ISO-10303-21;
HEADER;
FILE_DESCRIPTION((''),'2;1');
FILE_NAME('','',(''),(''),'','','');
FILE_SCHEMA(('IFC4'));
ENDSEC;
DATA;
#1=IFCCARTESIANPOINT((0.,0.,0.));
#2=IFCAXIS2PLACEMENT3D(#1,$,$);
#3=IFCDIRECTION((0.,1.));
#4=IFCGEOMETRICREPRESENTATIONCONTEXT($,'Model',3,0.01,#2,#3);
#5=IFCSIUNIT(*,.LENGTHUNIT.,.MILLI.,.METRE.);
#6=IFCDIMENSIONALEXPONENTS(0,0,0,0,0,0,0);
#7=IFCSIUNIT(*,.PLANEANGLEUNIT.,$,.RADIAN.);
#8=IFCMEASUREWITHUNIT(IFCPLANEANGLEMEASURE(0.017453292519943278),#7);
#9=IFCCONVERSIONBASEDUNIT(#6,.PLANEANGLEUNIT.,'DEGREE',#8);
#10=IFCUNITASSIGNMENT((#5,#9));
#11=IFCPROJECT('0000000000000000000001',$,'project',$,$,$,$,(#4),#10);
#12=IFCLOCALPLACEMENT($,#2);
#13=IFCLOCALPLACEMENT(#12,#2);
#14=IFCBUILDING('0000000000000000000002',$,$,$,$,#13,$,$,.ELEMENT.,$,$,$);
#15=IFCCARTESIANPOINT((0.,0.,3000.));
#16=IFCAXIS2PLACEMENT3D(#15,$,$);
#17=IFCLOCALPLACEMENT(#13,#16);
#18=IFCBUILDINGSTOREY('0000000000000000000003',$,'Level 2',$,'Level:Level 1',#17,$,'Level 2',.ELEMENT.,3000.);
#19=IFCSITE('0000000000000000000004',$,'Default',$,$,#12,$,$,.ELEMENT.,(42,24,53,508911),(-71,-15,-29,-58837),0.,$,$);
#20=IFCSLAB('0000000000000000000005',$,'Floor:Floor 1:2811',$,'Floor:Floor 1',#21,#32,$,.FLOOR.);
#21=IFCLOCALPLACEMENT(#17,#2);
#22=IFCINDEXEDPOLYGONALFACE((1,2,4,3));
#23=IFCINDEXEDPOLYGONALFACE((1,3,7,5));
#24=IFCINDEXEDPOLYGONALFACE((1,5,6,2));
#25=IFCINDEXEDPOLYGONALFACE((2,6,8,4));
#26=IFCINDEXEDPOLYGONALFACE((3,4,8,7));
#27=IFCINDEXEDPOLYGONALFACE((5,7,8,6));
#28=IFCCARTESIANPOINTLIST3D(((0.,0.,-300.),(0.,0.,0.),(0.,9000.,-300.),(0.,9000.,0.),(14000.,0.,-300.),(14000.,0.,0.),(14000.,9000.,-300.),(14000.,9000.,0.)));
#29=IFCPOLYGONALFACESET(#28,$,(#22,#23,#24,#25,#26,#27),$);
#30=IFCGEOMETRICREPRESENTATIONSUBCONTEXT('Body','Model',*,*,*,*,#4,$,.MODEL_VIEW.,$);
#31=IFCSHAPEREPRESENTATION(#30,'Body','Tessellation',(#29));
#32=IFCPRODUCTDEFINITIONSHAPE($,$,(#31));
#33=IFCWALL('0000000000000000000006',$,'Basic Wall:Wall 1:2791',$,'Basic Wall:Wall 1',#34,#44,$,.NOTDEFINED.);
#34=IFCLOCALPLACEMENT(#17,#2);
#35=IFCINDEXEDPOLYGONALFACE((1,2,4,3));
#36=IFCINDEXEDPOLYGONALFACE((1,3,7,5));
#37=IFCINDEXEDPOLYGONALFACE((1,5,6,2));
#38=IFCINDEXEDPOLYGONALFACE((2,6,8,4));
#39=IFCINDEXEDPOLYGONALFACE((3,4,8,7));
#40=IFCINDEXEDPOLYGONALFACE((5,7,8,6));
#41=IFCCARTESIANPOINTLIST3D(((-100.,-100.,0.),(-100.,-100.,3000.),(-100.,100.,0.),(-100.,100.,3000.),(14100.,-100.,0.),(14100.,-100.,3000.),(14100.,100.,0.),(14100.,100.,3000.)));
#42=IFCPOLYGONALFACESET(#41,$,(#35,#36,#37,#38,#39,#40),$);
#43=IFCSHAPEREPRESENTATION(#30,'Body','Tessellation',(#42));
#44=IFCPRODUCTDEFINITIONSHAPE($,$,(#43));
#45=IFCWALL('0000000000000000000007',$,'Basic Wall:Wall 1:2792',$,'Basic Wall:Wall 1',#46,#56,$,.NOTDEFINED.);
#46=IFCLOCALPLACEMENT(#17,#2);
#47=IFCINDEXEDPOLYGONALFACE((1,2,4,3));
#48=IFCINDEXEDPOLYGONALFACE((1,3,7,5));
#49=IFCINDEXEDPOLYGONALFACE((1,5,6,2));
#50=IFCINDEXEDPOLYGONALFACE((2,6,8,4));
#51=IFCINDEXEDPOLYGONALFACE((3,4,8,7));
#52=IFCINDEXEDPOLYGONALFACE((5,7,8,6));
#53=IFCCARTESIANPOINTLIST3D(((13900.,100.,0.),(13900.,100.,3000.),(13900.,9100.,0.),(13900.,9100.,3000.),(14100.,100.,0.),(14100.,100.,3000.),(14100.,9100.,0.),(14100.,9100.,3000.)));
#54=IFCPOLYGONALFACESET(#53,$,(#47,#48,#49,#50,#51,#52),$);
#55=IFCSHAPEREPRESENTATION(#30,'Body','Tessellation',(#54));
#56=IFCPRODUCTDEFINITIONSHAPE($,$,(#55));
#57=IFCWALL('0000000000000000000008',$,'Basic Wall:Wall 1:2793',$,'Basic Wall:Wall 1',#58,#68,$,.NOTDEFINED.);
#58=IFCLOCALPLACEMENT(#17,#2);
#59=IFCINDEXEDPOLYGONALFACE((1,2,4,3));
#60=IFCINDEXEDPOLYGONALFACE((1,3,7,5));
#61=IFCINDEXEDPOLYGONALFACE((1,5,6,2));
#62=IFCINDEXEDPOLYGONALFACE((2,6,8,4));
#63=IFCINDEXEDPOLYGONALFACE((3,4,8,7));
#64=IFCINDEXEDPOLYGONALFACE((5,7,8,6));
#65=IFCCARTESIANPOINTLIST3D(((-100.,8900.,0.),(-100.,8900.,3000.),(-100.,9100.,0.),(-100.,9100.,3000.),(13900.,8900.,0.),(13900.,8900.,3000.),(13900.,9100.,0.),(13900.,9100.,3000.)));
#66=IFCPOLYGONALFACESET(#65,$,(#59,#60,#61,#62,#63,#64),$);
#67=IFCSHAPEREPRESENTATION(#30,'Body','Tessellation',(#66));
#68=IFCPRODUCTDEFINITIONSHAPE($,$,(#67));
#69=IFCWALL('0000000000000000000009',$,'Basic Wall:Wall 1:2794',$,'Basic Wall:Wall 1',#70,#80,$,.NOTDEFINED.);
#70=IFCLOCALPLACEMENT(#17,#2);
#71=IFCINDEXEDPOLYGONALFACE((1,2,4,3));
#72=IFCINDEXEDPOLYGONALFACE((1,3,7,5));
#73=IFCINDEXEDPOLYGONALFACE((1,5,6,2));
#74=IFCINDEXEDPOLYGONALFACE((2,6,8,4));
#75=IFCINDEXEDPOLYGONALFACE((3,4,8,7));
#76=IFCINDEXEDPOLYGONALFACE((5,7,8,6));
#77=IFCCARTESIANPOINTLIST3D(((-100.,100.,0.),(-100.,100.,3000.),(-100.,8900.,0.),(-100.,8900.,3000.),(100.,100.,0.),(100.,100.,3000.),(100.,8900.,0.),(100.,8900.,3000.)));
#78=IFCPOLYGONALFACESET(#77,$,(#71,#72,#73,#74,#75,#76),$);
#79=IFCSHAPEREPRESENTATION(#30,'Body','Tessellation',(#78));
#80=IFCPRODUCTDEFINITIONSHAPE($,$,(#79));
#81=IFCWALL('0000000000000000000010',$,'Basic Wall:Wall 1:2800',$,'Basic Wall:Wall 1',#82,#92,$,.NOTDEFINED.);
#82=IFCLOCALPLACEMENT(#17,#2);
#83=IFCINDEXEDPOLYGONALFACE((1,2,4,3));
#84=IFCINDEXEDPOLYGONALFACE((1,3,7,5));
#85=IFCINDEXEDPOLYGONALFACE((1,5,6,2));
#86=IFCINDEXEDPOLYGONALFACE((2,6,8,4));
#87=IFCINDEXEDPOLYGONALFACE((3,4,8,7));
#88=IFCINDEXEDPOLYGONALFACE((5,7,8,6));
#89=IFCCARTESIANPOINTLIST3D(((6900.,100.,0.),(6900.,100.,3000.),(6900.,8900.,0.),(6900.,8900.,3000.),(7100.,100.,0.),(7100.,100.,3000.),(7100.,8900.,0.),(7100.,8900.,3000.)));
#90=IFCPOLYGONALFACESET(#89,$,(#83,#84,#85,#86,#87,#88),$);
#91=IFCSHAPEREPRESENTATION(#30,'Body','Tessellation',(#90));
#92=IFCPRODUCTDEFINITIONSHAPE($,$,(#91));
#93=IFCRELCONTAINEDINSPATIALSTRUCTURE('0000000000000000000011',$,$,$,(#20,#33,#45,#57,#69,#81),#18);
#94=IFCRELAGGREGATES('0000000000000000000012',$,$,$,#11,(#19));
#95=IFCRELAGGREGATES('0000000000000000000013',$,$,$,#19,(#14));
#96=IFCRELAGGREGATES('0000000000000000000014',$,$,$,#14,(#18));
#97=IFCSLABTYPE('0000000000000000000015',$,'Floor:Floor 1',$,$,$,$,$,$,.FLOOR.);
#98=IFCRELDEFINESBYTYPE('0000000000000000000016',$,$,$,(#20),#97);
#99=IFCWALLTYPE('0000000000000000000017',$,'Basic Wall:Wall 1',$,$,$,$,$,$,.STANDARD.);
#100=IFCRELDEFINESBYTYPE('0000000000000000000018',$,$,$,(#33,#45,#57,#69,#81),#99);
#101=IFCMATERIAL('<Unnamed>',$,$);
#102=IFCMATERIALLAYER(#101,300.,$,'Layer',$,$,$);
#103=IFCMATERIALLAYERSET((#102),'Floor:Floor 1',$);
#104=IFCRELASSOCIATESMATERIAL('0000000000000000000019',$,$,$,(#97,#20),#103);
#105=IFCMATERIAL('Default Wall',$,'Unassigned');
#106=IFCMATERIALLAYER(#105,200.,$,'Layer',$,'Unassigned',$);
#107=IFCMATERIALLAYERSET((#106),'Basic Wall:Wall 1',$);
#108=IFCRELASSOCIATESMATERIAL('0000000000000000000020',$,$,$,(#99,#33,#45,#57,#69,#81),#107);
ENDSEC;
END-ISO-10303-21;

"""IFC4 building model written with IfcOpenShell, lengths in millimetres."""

from ifc_helpers import new_model, entity, si_unit, converted_unit, direction, frame, frame_2d, origin, origin_2d_with_axis, place, context, subcontext, project, spatial, rectangle, extrude, material, layer, layer_set, layer_usage, type_object, element, save


model = new_model("IFC4")

# Units and contexts
model_context = context("Model", 3, precision=0.01, world=origin(), true_north=direction((0.0, 1.0)))
body_context = subcontext(model_context, "Body", "Model", "MODEL_VIEW")
ifc_project = project(units=[si_unit("LENGTHUNIT", "METRE", prefix="MILLI"), converted_unit("PLANEANGLEUNIT", "DEGREE", entity("IfcPlaneAngleMeasure", 0.017453292519943278), si_unit("PLANEANGLEUNIT", "RADIAN"), dimensions=[0, 0, 0, 0, 0, 0, 0])], contexts=[model_context])

# Site, building, storey
site_placement = place(None, origin())
site = spatial("IfcSite", under=ifc_project, at=site_placement, Name="Default", CompositionType="ELEMENT", RefLatitude=(42, 24, 53, 508911), RefLongitude=(-71, -15, -29, -58837), RefElevation=0.0)
building_placement = place(site_placement, origin())
building = spatial("IfcBuilding", under=site, at=building_placement, CompositionType="ELEMENT")
storey_placement = place(building_placement, frame((0.0, 0.0, 3000.0)))
storey = spatial("IfcBuildingStorey", under=building, at=storey_placement, Name="Level 2", ObjectType="Level:Level 1", LongName="Level 2", CompositionType="ELEMENT", Elevation=3000.0)

# Slab
ifc_material_1 = material(Name="<Unnamed>")
ifc_layer_1 = layer(ifc_material_1, 300.0, Name="Layer")
ifc_layer_set_1 = layer_set([ifc_layer_1], Name="Floor:Floor 1")
ifc_layer_usage_1 = layer_usage(ifc_layer_set_1, "AXIS3", "POSITIVE", 0.0)
slab_type = type_object("IfcSlabType", Name="Floor:Floor 1", PredefinedType="FLOOR", material=ifc_layer_set_1)
slab_placement = place(storey_placement, origin())
element("IfcSlab", 1, at=slab_placement, inside=storey, type_object=slab_type, material=ifc_layer_usage_1, Name="Floor:Floor 1:2811", ObjectType="Floor:Floor 1", PredefinedType="FLOOR", context=body_context, shape_type="SweptSolid", body=[
    extrude(rectangle(XDim=9000.0, YDim=14000.0, at=origin_2d_with_axis()), frame((7000.0, 4500.0, 0.0), z_axis=(0.0, 0.0, -1.0), x_axis=(0.0, 1.0, 0.0)), (0.0, 0.0, 1.0), 300.0),
])

# Walls
ifc_material_2 = material(Name="Default Wall", Category="Unassigned")
ifc_layer_2 = layer(ifc_material_2, 200.0, Name="Layer", Category="Unassigned")
ifc_layer_set_2 = layer_set([ifc_layer_2], Name="Basic Wall:Wall 1")
ifc_layer_usage_2 = layer_usage(ifc_layer_set_2, "AXIS2", "NEGATIVE", 100.0)
wall_type = type_object("IfcWallType", Name="Basic Wall:Wall 1", PredefinedType="STANDARD", material=ifc_layer_set_2)
wall_1_placement = place(storey_placement, frame((-100.0, 0.0, 0.0)))
element("IfcWall", 2, at=wall_1_placement, inside=storey, type_object=wall_type, material=ifc_layer_usage_2, Name="Basic Wall:Wall 1:2791", ObjectType="Basic Wall:Wall 1", PredefinedType="NOTDEFINED", context=body_context, shape_type="SweptSolid", body=[
    extrude(rectangle(XDim=14200.0, YDim=200.0, at=frame_2d((7100.0, 0.0), x_axis=(-1.0, 0.0))), origin(), (0.0, 0.0, 1.0), 3000.0),
])
ifc_layer_usage_3 = layer_usage(ifc_layer_set_2, "AXIS2", "NEGATIVE", 100.0)
wall_2_placement = place(storey_placement, frame((14000.0, 100.0, 0.0), z_axis=(0.0, 0.0, 1.0), x_axis=(0.0, 1.0, 0.0)))
element("IfcWall", 3, at=wall_2_placement, inside=storey, type_object=wall_type, material=ifc_layer_usage_3, Name="Basic Wall:Wall 1:2792", ObjectType="Basic Wall:Wall 1", PredefinedType="NOTDEFINED", context=body_context, shape_type="SweptSolid", body=[
    extrude(rectangle(XDim=9000.0, YDim=200.0, at=frame_2d((4500.0, 0.0), x_axis=(-1.0, 0.0))), origin(), (0.0, 0.0, 1.0), 3000.0),
])
ifc_layer_usage_4 = layer_usage(ifc_layer_set_2, "AXIS2", "NEGATIVE", 100.0)
wall_3_placement = place(storey_placement, frame((13900.0, 9000.0, 0.0), z_axis=(0.0, 0.0, 1.0), x_axis=(-1.0, 0.0, 0.0)))
element("IfcWall", 4, at=wall_3_placement, inside=storey, type_object=wall_type, material=ifc_layer_usage_4, Name="Basic Wall:Wall 1:2793", ObjectType="Basic Wall:Wall 1", PredefinedType="NOTDEFINED", context=body_context, shape_type="SweptSolid", body=[
    extrude(rectangle(XDim=14000.0, YDim=200.0, at=frame_2d((7000.0, 0.0), x_axis=(-1.0, 0.0))), origin(), (0.0, 0.0, 1.0), 3000.0),
])
ifc_layer_usage_5 = layer_usage(ifc_layer_set_2, "AXIS2", "NEGATIVE", 100.0)
wall_4_placement = place(storey_placement, frame((0.0, 8900.0, 0.0), z_axis=(0.0, 0.0, 1.0), x_axis=(0.0, -1.0, 0.0)))
element("IfcWall", 5, at=wall_4_placement, inside=storey, type_object=wall_type, material=ifc_layer_usage_5, Name="Basic Wall:Wall 1:2794", ObjectType="Basic Wall:Wall 1", PredefinedType="NOTDEFINED", context=body_context, shape_type="SweptSolid", body=[
    extrude(rectangle(XDim=8800.0, YDim=200.0, at=frame_2d((4400.0, 0.0), x_axis=(-1.0, 0.0))), origin(), (0.0, 0.0, 1.0), 3000.0),
])
ifc_layer_usage_6 = layer_usage(ifc_layer_set_2, "AXIS2", "NEGATIVE", 100.0)
wall_5_placement = place(storey_placement, frame((7000.0, 100.0, 0.0), z_axis=(0.0, 0.0, 1.0), x_axis=(0.0, 1.0, 0.0)))
element("IfcWall", 6, at=wall_5_placement, inside=storey, type_object=wall_type, material=ifc_layer_usage_6, Name="Basic Wall:Wall 1:2800", ObjectType="Basic Wall:Wall 1", PredefinedType="NOTDEFINED", context=body_context, shape_type="SweptSolid", body=[
    extrude(rectangle(XDim=8800.0, YDim=200.0, at=frame_2d((4400.0, 0.0), x_axis=(-1.0, 0.0))), origin(), (0.0, 0.0, 1.0), 3000.0),
])

save(model, "model.ifc")
